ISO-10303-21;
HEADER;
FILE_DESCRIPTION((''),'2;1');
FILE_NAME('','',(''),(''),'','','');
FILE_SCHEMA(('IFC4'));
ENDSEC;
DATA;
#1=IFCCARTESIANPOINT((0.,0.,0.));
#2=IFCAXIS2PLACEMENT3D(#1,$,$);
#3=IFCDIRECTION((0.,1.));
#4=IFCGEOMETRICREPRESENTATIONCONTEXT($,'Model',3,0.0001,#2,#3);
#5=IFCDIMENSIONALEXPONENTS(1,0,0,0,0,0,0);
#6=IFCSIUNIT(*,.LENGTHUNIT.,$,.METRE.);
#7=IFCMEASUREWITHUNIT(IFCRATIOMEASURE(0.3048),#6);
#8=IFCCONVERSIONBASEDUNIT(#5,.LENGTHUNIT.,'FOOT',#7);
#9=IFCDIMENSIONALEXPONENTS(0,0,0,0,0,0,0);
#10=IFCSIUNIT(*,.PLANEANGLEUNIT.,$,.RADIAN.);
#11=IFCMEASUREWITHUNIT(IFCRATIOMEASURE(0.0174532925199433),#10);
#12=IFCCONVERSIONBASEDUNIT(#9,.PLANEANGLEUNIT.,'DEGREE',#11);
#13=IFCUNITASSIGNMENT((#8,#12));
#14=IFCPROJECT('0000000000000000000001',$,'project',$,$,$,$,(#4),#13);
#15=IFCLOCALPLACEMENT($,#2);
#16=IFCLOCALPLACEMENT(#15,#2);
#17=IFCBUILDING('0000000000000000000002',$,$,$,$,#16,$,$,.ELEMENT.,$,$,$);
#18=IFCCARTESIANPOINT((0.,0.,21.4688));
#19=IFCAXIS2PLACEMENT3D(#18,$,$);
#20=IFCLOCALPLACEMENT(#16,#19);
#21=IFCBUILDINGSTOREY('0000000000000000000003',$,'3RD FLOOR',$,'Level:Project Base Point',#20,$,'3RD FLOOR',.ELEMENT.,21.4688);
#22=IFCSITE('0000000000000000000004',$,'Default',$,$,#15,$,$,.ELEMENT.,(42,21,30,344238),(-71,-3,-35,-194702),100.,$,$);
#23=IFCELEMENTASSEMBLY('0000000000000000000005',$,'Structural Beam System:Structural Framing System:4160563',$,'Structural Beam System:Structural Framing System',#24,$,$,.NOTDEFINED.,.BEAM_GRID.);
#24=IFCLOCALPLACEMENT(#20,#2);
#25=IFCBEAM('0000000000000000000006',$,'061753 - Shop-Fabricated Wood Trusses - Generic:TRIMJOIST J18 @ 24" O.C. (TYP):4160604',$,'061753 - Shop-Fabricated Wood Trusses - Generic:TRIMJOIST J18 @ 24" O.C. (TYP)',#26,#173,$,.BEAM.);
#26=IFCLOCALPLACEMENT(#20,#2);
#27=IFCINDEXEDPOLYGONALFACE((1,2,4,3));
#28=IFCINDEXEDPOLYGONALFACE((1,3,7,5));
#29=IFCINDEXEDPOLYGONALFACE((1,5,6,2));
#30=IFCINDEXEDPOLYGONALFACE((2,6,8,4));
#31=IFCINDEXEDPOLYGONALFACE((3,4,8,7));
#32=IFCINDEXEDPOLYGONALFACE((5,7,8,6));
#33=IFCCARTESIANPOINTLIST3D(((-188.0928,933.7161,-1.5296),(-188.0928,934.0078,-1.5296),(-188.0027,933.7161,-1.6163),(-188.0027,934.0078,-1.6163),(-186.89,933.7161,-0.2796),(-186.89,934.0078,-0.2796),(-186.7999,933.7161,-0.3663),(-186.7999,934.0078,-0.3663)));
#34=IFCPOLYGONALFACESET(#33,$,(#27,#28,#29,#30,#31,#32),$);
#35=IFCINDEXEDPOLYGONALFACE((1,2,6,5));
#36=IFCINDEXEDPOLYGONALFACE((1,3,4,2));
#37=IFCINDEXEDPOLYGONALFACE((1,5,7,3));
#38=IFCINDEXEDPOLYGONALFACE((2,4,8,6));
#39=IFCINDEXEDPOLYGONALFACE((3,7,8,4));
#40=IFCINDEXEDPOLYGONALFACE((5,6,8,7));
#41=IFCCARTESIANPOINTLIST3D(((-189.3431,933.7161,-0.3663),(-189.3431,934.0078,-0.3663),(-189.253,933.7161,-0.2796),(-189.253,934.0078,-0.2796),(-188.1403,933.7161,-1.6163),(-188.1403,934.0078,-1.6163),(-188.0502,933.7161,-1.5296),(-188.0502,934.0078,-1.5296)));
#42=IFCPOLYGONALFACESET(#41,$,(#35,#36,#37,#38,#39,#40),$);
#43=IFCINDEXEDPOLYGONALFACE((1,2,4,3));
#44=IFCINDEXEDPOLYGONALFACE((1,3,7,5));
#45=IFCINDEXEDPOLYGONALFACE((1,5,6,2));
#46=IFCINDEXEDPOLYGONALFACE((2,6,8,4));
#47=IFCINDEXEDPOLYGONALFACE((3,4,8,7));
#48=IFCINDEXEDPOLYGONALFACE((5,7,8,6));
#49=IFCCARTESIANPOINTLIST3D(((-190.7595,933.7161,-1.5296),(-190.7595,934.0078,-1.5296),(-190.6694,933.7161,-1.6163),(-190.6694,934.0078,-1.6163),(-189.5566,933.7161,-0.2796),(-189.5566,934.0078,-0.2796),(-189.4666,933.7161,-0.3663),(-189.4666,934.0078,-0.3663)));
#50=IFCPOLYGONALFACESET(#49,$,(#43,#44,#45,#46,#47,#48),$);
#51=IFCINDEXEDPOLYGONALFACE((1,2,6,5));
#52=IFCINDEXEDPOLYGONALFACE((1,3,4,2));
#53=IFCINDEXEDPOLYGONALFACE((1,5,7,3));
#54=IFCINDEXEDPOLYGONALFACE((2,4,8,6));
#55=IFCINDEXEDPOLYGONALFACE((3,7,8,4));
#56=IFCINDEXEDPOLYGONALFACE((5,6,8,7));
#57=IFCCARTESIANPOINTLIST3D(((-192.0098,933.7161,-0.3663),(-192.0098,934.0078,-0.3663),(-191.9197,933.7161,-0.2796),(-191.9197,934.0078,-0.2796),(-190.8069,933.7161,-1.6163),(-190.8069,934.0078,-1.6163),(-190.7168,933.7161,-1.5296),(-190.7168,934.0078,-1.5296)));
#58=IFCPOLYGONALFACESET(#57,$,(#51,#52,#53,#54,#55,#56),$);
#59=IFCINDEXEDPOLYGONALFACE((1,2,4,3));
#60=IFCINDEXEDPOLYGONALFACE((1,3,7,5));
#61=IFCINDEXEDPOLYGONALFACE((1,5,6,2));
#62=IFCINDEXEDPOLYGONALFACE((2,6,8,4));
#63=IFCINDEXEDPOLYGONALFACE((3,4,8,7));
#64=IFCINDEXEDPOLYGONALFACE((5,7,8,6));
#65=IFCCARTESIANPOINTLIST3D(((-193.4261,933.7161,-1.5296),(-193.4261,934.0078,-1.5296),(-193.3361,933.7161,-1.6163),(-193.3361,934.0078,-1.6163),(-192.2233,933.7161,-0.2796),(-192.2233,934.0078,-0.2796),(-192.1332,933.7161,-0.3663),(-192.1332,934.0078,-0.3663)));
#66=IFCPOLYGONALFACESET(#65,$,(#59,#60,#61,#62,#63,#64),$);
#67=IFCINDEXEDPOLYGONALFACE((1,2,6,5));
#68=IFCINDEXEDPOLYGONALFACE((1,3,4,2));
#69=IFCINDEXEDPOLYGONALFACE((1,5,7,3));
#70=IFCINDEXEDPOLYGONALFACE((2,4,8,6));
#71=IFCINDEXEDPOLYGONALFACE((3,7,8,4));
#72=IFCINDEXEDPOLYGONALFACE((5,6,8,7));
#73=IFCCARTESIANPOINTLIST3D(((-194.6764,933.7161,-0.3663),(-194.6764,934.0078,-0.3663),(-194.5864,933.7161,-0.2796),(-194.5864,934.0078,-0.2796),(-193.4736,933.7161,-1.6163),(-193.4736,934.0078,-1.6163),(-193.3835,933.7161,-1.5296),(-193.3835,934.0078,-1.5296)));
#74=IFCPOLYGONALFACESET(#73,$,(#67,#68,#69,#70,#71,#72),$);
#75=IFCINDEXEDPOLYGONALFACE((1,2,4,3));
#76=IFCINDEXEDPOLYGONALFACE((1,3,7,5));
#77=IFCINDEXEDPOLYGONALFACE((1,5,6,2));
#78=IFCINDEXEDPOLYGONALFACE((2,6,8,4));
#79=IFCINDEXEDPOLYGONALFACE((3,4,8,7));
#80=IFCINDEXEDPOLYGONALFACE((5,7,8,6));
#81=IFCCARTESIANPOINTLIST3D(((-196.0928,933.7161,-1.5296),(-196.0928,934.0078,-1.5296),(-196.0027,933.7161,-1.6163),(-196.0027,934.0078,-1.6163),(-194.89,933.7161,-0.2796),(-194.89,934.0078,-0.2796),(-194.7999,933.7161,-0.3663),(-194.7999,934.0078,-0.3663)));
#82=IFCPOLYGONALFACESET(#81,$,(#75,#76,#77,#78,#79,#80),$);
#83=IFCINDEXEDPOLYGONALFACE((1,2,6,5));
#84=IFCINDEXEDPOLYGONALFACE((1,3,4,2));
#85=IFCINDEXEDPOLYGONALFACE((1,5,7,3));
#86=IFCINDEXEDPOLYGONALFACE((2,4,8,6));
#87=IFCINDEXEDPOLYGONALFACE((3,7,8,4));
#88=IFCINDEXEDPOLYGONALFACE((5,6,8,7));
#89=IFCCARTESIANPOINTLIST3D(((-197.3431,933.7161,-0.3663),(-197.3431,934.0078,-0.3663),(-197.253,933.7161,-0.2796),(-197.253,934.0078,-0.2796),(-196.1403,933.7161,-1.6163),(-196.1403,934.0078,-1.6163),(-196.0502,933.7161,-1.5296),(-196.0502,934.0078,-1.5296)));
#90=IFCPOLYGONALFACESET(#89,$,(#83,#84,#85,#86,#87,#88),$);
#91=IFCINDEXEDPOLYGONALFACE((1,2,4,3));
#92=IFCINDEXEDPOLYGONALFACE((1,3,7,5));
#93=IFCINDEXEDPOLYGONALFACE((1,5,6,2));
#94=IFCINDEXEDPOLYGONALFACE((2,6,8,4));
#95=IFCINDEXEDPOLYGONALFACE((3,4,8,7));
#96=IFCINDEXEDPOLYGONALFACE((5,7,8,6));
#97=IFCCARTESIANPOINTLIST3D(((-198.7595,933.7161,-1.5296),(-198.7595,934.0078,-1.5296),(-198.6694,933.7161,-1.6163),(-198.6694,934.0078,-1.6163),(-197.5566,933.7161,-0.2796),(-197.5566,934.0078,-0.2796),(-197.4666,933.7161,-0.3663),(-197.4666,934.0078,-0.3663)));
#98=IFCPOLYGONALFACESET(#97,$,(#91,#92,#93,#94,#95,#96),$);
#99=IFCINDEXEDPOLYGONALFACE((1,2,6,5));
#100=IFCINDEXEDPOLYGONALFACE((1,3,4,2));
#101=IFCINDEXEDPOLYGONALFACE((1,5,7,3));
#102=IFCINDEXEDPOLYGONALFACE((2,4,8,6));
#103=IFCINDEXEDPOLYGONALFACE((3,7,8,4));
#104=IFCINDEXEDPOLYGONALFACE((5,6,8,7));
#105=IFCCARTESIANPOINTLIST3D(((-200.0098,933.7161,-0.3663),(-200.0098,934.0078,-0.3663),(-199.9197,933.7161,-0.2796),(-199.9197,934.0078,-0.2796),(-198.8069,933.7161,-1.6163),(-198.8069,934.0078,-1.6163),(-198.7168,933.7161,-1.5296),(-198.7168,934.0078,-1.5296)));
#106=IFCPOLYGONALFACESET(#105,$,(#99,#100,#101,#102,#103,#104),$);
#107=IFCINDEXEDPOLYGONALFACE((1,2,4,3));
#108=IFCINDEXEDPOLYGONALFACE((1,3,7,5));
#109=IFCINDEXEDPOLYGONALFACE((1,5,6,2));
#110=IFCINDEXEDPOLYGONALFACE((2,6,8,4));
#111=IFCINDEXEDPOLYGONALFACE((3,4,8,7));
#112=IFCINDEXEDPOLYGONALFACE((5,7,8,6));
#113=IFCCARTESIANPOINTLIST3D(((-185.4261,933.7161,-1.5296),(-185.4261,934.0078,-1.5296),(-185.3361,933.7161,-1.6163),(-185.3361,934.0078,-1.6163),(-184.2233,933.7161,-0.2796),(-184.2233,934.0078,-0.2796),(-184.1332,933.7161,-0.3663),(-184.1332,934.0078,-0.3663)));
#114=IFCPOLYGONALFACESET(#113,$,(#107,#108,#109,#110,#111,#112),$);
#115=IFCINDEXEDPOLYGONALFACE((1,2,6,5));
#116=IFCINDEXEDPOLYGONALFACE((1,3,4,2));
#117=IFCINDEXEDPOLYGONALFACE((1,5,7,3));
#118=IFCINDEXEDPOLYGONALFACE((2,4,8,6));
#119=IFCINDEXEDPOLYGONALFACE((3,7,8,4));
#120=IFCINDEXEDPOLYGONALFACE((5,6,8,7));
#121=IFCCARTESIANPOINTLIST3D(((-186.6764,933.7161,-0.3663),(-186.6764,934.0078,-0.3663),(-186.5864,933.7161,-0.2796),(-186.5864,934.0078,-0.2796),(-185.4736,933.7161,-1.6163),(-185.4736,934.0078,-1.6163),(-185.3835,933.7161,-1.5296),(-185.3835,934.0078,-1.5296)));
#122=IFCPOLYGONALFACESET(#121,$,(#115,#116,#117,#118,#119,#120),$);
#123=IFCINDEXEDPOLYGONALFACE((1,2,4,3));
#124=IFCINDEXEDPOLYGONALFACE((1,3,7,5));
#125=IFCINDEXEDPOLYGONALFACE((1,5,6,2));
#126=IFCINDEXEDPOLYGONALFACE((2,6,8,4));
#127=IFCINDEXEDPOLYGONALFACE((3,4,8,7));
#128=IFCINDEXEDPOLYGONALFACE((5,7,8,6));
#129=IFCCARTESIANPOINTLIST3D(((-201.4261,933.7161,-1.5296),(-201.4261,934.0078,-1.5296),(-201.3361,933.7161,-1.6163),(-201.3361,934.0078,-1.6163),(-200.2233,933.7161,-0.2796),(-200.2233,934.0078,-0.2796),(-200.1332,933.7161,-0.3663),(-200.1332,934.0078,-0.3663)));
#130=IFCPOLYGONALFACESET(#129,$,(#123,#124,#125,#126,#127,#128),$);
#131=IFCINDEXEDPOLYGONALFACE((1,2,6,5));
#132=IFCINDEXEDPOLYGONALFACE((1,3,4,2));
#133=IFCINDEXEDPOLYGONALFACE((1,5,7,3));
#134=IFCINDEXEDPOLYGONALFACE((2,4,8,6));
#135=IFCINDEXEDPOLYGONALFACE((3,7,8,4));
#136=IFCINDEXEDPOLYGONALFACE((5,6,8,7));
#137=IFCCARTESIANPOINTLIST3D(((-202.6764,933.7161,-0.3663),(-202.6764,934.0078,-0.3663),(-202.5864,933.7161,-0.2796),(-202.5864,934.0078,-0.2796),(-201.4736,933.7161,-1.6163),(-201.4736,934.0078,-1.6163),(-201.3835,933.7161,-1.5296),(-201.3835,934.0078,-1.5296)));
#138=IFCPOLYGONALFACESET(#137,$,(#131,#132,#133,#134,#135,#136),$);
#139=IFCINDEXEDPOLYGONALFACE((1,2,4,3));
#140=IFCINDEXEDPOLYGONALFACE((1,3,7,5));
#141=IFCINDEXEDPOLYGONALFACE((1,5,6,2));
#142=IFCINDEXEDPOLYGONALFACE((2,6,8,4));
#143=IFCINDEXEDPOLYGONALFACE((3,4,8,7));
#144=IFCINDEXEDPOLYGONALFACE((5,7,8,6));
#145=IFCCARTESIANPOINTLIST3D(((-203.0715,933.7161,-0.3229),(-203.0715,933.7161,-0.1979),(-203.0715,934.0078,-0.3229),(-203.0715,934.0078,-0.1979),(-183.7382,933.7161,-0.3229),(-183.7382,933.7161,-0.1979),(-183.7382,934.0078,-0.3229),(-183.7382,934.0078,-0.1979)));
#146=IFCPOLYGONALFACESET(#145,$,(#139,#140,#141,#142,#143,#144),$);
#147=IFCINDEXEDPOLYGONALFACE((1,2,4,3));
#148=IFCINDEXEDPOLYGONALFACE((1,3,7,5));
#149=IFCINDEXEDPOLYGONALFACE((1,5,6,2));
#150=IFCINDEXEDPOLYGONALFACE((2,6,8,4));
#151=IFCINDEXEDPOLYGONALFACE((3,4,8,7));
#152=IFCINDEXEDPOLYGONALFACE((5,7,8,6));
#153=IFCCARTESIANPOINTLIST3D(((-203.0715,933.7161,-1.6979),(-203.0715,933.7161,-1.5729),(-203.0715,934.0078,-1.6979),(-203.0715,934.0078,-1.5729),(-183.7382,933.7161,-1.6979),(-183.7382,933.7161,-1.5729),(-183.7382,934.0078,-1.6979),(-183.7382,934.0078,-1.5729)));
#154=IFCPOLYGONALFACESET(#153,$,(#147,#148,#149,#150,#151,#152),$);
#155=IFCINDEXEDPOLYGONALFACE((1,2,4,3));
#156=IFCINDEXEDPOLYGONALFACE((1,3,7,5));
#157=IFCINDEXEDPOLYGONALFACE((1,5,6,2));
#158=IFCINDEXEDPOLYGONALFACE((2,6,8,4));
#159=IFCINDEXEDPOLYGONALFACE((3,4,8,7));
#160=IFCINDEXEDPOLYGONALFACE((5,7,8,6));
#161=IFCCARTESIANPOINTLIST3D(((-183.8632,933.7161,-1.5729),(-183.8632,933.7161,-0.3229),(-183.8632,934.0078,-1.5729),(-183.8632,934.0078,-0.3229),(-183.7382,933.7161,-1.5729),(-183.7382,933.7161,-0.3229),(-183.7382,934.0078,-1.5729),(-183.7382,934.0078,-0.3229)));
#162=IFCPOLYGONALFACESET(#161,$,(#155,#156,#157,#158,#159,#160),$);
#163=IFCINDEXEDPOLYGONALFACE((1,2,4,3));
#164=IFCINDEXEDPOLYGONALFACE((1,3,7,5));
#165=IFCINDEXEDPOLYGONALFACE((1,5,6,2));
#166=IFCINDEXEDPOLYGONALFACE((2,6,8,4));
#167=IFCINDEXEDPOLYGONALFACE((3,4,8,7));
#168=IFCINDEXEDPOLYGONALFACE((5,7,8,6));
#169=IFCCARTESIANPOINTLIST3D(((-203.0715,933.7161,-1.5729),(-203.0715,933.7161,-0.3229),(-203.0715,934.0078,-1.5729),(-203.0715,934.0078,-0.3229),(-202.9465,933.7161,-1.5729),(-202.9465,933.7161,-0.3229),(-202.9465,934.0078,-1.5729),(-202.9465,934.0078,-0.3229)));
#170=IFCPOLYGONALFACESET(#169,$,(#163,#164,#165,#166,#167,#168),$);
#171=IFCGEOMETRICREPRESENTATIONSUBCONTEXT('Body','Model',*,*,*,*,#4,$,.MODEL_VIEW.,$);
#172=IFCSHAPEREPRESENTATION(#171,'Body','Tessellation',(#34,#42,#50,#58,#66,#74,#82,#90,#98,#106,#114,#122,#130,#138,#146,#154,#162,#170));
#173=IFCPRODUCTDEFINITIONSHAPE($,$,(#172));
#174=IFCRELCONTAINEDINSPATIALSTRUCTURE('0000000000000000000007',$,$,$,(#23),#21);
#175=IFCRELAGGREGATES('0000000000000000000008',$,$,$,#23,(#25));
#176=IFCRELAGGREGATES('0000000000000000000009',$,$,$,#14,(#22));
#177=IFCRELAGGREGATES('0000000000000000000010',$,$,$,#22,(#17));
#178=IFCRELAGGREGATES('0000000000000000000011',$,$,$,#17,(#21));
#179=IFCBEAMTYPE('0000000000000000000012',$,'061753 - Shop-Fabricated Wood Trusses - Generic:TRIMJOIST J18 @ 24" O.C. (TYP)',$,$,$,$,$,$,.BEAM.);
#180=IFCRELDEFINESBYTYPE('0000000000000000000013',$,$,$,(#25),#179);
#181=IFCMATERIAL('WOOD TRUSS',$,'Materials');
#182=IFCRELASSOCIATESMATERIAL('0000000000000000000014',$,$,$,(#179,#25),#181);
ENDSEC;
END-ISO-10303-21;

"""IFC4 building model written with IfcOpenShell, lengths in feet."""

from ifc_helpers import new_model, entity, si_unit, converted_unit, direction, frame, frame_2d, origin, origin_2d_with_axis, place, context, subcontext, project, spatial, rectangle, extrude, source, transform, mapped, material, material_profile, profile_set, profile_usage, type_object, type_shapes, element, aggregate, save


model = new_model("IFC4")

# Units and contexts
model_context = context("Model", 3, precision=0.0001, world=origin(), true_north=direction((0.0, 1.0)))
body_context = subcontext(model_context, "Body", "Model", "MODEL_VIEW")
ifc_project = project(units=[converted_unit("LENGTHUNIT", "FOOT", entity("IfcRatioMeasure", 0.3048), si_unit("LENGTHUNIT", "METRE"), dimensions=[1, 0, 0, 0, 0, 0, 0]), converted_unit("PLANEANGLEUNIT", "DEGREE", entity("IfcRatioMeasure", 0.0174532925199433), si_unit("PLANEANGLEUNIT", "RADIAN"), dimensions=[0, 0, 0, 0, 0, 0, 0])], contexts=[model_context])

# Site, building, storey
site_placement = place(None, origin())
site = spatial("IfcSite", under=ifc_project, at=site_placement, Name="Default", CompositionType="ELEMENT", RefLatitude=(42, 21, 30, 344238), RefLongitude=(-71, -3, -35, -194702), RefElevation=100.0)
building_placement = place(site_placement, origin())
building = spatial("IfcBuilding", under=site, at=building_placement, CompositionType="ELEMENT")
storey_placement = place(building_placement, frame((0.0, 0.0, 21.4688)))
storey = spatial("IfcBuildingStorey", under=building, at=storey_placement, Name="3RD FLOOR", ObjectType="Level:Project Base Point", LongName="3RD FLOOR", CompositionType="ELEMENT", Elevation=21.4688)

# Element assembly, beam
ifc_material = material(Name="WOOD TRUSS", Category="Materials")
ifc_material_profile_1 = material_profile(ifc_material, rectangle(XDim=1.7347, YDim=0.125, at=frame_2d((0.0, 0.0), x_axis=(1.0, 0.0))), Name="TRIMJOIST J18 @ 24\" O.C. (TYP)")
ifc_material_profile_2 = material_profile(ifc_material, rectangle(XDim=1.7347, YDim=0.125, at=frame_2d((0.0, 0.0), x_axis=(1.0, 0.0))), Name="TRIMJOIST J18 @ 24\" O.C. (TYP)")
ifc_material_profile_3 = material_profile(ifc_material, rectangle(XDim=1.7347, YDim=0.125, at=frame_2d((0.0, 0.0), x_axis=(1.0, 0.0))), Name="TRIMJOIST J18 @ 24\" O.C. (TYP)")
ifc_material_profile_4 = material_profile(ifc_material, rectangle(XDim=1.7347, YDim=0.125, at=frame_2d((0.0, 0.0), x_axis=(1.0, 0.0))), Name="TRIMJOIST J18 @ 24\" O.C. (TYP)")
ifc_material_profile_5 = material_profile(ifc_material, rectangle(XDim=1.7347, YDim=0.125, at=frame_2d((0.0, 0.0), x_axis=(1.0, 0.0))), Name="TRIMJOIST J18 @ 24\" O.C. (TYP)")
ifc_material_profile_6 = material_profile(ifc_material, rectangle(XDim=1.7347, YDim=0.125, at=frame_2d((0.0, 0.0), x_axis=(1.0, 0.0))), Name="TRIMJOIST J18 @ 24\" O.C. (TYP)")
ifc_material_profile_7 = material_profile(ifc_material, rectangle(XDim=1.7347, YDim=0.125, at=frame_2d((0.0, 0.0), x_axis=(1.0, 0.0))), Name="TRIMJOIST J18 @ 24\" O.C. (TYP)")
ifc_material_profile_8 = material_profile(ifc_material, rectangle(XDim=1.7347, YDim=0.125, at=frame_2d((0.0, 0.0), x_axis=(1.0, 0.0))), Name="TRIMJOIST J18 @ 24\" O.C. (TYP)")
ifc_material_profile_9 = material_profile(ifc_material, rectangle(XDim=1.7347, YDim=0.125, at=frame_2d((0.0, 0.0), x_axis=(1.0, 0.0))), Name="TRIMJOIST J18 @ 24\" O.C. (TYP)")
ifc_material_profile_10 = material_profile(ifc_material, rectangle(XDim=1.7347, YDim=0.125, at=origin_2d_with_axis()), Name="TRIMJOIST J18 @ 24\" O.C. (TYP)")
ifc_material_profile_11 = material_profile(ifc_material, rectangle(XDim=0.125, YDim=0.2917, at=origin_2d_with_axis()), Name="TRIMJOIST J18 @ 24\" O.C. (TYP)")
ifc_material_profile_12 = material_profile(ifc_material, rectangle(XDim=0.125, YDim=0.2917, at=origin_2d_with_axis()), Name="TRIMJOIST J18 @ 24\" O.C. (TYP)")
ifc_material_profile_13 = material_profile(ifc_material, rectangle(XDim=1.25, YDim=0.2917, at=origin_2d_with_axis()), Name="TRIMJOIST J18 @ 24\" O.C. (TYP)")
ifc_material_profile_14 = material_profile(ifc_material, rectangle(XDim=1.25, YDim=0.2917, at=origin_2d_with_axis()), Name="TRIMJOIST J18 @ 24\" O.C. (TYP)")
ifc_profile_set = profile_set([ifc_material_profile_1, ifc_material_profile_2, ifc_material_profile_3, ifc_material_profile_4, ifc_material_profile_5, ifc_material_profile_6, ifc_material_profile_7, ifc_material_profile_8, ifc_material_profile_9, ifc_material_profile_10, ifc_material_profile_11, ifc_material_profile_12, ifc_material_profile_13, ifc_material_profile_14], Name="TRIMJOIST J18 @ 24\" O.C. (TYP)")
beam_type_1 = type_object("IfcBeamType", Name="061753 - Shop-Fabricated Wood Trusses - Generic:TRIMJOIST J18 @ 24\" O.C. (TYP)", PredefinedType="BEAM", material=ifc_profile_set)
shared_shape_1 = source(origin(), body_context, "Body", "SweptSolid", [
    extrude(rectangle(XDim=1.7347, YDim=0.125, at=frame_2d((0.0, 0.0), x_axis=(1.0, 0.0))), frame((5.9585, -0.1458, 0.0), z_axis=(0.0, 1.0, 0.0), x_axis=(0.693383, 0.0, 0.720569)), (0.0, 0.0, 1.0), 0.2917),
    extrude(rectangle(XDim=1.7347, YDim=0.125, at=origin_2d_with_axis()), frame((4.7082, -0.1458, 0.0), z_axis=(0.0, 1.0, 0.0), x_axis=(0.693383, 0.0, -0.720569)), (0.0, 0.0, 1.0), 0.2917),
    extrude(rectangle(XDim=1.7347, YDim=0.125, at=frame_2d((0.0, 0.0), x_axis=(1.0, 0.0))), frame((3.2918, -0.1458, 0.0), z_axis=(0.0, 1.0, 0.0), x_axis=(0.693383, 0.0, 0.720569)), (0.0, 0.0, 1.0), 0.2917),
    extrude(rectangle(XDim=1.7347, YDim=0.125, at=frame_2d((0.0, 0.0), x_axis=(1.0, 0.0))), frame((2.0415, -0.1458, 0.0), z_axis=(0.0, 1.0, 0.0), x_axis=(0.693383, 0.0, -0.720569)), (0.0, 0.0, 1.0), 0.2917),
    extrude(rectangle(XDim=1.7347, YDim=0.125, at=frame_2d((0.0, 0.0), x_axis=(1.0, 0.0))), frame((0.6251, -0.1458, 0.0), z_axis=(0.0, 1.0, 0.0), x_axis=(0.693383, 0.0, 0.720569)), (0.0, 0.0, 1.0), 0.2917),
    extrude(rectangle(XDim=1.7347, YDim=0.125, at=frame_2d((0.0, 0.0), x_axis=(1.0, 0.0))), frame((-0.6251, -0.1458, 0.0), z_axis=(0.0, 1.0, 0.0), x_axis=(0.693383, 0.0, -0.720569)), (0.0, 0.0, 1.0), 0.2917),
    extrude(rectangle(XDim=1.7347, YDim=0.125, at=frame_2d((0.0, 0.0), x_axis=(1.0, 0.0))), frame((-2.0415, -0.1458, 0.0), z_axis=(0.0, 1.0, 0.0), x_axis=(0.693383, 0.0, 0.720569)), (0.0, 0.0, 1.0), 0.2917),
    extrude(rectangle(XDim=1.7347, YDim=0.125, at=origin_2d_with_axis()), frame((-3.2918, -0.1458, 0.0), z_axis=(0.0, 1.0, 0.0), x_axis=(0.693383, 0.0, -0.720569)), (0.0, 0.0, 1.0), 0.2917),
    extrude(rectangle(XDim=1.7347, YDim=0.125, at=frame_2d((0.0, 0.0), x_axis=(1.0, 0.0))), frame((-4.7082, -0.1458, 0.0), z_axis=(0.0, 1.0, 0.0), x_axis=(0.693383, 0.0, 0.720569)), (0.0, 0.0, 1.0), 0.2917),
    extrude(rectangle(XDim=1.7347, YDim=0.125, at=frame_2d((0.0, 0.0), x_axis=(1.0, 0.0))), frame((-5.9585, -0.1458, 0.0), z_axis=(0.0, 1.0, 0.0), x_axis=(0.693383, 0.0, -0.720569)), (0.0, 0.0, 1.0), 0.2917),
    extrude(rectangle(XDim=1.7347, YDim=0.125, at=frame_2d((0.0, 0.0), x_axis=(1.0, 0.0))), frame((8.6251, -0.1458, 0.0), z_axis=(0.0, 1.0, 0.0), x_axis=(0.693383, 0.0, 0.720569)), (0.0, 0.0, 1.0), 0.2917),
    extrude(rectangle(XDim=1.7347, YDim=0.125, at=origin_2d_with_axis()), frame((7.3749, -0.1458, 0.0), z_axis=(0.0, 1.0, 0.0), x_axis=(0.693383, 0.0, -0.720569)), (0.0, 0.0, 1.0), 0.2917),
    extrude(rectangle(XDim=1.7347, YDim=0.125, at=frame_2d((0.0, 0.0), x_axis=(1.0, 0.0))), frame((-7.3749, -0.1458, 0.0), z_axis=(0.0, 1.0, 0.0), x_axis=(0.693383, 0.0, 0.720569)), (0.0, 0.0, 1.0), 0.2917),
    extrude(rectangle(XDim=1.7347, YDim=0.125, at=origin_2d_with_axis()), frame((-8.6251, -0.1458, 0.0), z_axis=(0.0, 1.0, 0.0), x_axis=(0.693383, 0.0, -0.720569)), (0.0, 0.0, 1.0), 0.2917),
    extrude(rectangle(XDim=0.125, YDim=0.2917, at=origin_2d_with_axis()), frame((-9.6667, 0.0, 0.6875), z_axis=(1.0, 0.0, 0.0), x_axis=(0.0, 0.0, -1.0)), (0.0, 0.0, 1.0), 19.3333),
    extrude(rectangle(XDim=0.125, YDim=0.2917, at=origin_2d_with_axis()), frame((-9.6667, 0.0, -0.6875), z_axis=(1.0, 0.0, 0.0), x_axis=(0.0, 0.0, -1.0)), (0.0, 0.0, 1.0), 19.3333),
    extrude(rectangle(XDim=1.25, YDim=0.2917, at=origin_2d_with_axis()), frame((9.5417, 0.0, 0.0), z_axis=(1.0, 0.0, 0.0), x_axis=(0.0, 0.0, -1.0)), (0.0, 0.0, 1.0), 0.125),
    extrude(rectangle(XDim=1.25, YDim=0.2917, at=origin_2d_with_axis()), frame((-9.6667, 0.0, 0.0), z_axis=(1.0, 0.0, 0.0), x_axis=(0.0, 0.0, -1.0)), (0.0, 0.0, 1.0), 0.125),
])
type_shapes(beam_type_1, [shared_shape_1])
assembly_1_placement = place(storey_placement, origin())
assembly_1 = element("IfcElementAssembly", 1, at=assembly_1_placement, inside=storey, Name="Structural Beam System:Structural Framing System:4160563", ObjectType="Structural Beam System:Structural Framing System", AssemblyPlace="NOTDEFINED", PredefinedType="BEAM_GRID")
ifc_profile_usage_1 = profile_usage(ifc_profile_set, cardinal=8)
beam_1_placement = place(assembly_1_placement, frame((-193.4048, 933.8619, -0.9479)))
beam_1 = element("IfcBeam", 2, at=beam_1_placement, type_object=beam_type_1, material=ifc_profile_usage_1, Name="061753 - Shop-Fabricated Wood Trusses - Generic:TRIMJOIST J18 @ 24\" O.C. (TYP):4160604", ObjectType="061753 - Shop-Fabricated Wood Trusses - Generic:TRIMJOIST J18 @ 24\" O.C. (TYP)", PredefinedType="BEAM", context=body_context, shape_type="MappedRepresentation", body=[
    mapped(shared_shape_1, transform((0.0, 0.0, 0.0), scale=1.0)),
])
aggregate(assembly_1, [beam_1])

save(model, "model.ifc")
